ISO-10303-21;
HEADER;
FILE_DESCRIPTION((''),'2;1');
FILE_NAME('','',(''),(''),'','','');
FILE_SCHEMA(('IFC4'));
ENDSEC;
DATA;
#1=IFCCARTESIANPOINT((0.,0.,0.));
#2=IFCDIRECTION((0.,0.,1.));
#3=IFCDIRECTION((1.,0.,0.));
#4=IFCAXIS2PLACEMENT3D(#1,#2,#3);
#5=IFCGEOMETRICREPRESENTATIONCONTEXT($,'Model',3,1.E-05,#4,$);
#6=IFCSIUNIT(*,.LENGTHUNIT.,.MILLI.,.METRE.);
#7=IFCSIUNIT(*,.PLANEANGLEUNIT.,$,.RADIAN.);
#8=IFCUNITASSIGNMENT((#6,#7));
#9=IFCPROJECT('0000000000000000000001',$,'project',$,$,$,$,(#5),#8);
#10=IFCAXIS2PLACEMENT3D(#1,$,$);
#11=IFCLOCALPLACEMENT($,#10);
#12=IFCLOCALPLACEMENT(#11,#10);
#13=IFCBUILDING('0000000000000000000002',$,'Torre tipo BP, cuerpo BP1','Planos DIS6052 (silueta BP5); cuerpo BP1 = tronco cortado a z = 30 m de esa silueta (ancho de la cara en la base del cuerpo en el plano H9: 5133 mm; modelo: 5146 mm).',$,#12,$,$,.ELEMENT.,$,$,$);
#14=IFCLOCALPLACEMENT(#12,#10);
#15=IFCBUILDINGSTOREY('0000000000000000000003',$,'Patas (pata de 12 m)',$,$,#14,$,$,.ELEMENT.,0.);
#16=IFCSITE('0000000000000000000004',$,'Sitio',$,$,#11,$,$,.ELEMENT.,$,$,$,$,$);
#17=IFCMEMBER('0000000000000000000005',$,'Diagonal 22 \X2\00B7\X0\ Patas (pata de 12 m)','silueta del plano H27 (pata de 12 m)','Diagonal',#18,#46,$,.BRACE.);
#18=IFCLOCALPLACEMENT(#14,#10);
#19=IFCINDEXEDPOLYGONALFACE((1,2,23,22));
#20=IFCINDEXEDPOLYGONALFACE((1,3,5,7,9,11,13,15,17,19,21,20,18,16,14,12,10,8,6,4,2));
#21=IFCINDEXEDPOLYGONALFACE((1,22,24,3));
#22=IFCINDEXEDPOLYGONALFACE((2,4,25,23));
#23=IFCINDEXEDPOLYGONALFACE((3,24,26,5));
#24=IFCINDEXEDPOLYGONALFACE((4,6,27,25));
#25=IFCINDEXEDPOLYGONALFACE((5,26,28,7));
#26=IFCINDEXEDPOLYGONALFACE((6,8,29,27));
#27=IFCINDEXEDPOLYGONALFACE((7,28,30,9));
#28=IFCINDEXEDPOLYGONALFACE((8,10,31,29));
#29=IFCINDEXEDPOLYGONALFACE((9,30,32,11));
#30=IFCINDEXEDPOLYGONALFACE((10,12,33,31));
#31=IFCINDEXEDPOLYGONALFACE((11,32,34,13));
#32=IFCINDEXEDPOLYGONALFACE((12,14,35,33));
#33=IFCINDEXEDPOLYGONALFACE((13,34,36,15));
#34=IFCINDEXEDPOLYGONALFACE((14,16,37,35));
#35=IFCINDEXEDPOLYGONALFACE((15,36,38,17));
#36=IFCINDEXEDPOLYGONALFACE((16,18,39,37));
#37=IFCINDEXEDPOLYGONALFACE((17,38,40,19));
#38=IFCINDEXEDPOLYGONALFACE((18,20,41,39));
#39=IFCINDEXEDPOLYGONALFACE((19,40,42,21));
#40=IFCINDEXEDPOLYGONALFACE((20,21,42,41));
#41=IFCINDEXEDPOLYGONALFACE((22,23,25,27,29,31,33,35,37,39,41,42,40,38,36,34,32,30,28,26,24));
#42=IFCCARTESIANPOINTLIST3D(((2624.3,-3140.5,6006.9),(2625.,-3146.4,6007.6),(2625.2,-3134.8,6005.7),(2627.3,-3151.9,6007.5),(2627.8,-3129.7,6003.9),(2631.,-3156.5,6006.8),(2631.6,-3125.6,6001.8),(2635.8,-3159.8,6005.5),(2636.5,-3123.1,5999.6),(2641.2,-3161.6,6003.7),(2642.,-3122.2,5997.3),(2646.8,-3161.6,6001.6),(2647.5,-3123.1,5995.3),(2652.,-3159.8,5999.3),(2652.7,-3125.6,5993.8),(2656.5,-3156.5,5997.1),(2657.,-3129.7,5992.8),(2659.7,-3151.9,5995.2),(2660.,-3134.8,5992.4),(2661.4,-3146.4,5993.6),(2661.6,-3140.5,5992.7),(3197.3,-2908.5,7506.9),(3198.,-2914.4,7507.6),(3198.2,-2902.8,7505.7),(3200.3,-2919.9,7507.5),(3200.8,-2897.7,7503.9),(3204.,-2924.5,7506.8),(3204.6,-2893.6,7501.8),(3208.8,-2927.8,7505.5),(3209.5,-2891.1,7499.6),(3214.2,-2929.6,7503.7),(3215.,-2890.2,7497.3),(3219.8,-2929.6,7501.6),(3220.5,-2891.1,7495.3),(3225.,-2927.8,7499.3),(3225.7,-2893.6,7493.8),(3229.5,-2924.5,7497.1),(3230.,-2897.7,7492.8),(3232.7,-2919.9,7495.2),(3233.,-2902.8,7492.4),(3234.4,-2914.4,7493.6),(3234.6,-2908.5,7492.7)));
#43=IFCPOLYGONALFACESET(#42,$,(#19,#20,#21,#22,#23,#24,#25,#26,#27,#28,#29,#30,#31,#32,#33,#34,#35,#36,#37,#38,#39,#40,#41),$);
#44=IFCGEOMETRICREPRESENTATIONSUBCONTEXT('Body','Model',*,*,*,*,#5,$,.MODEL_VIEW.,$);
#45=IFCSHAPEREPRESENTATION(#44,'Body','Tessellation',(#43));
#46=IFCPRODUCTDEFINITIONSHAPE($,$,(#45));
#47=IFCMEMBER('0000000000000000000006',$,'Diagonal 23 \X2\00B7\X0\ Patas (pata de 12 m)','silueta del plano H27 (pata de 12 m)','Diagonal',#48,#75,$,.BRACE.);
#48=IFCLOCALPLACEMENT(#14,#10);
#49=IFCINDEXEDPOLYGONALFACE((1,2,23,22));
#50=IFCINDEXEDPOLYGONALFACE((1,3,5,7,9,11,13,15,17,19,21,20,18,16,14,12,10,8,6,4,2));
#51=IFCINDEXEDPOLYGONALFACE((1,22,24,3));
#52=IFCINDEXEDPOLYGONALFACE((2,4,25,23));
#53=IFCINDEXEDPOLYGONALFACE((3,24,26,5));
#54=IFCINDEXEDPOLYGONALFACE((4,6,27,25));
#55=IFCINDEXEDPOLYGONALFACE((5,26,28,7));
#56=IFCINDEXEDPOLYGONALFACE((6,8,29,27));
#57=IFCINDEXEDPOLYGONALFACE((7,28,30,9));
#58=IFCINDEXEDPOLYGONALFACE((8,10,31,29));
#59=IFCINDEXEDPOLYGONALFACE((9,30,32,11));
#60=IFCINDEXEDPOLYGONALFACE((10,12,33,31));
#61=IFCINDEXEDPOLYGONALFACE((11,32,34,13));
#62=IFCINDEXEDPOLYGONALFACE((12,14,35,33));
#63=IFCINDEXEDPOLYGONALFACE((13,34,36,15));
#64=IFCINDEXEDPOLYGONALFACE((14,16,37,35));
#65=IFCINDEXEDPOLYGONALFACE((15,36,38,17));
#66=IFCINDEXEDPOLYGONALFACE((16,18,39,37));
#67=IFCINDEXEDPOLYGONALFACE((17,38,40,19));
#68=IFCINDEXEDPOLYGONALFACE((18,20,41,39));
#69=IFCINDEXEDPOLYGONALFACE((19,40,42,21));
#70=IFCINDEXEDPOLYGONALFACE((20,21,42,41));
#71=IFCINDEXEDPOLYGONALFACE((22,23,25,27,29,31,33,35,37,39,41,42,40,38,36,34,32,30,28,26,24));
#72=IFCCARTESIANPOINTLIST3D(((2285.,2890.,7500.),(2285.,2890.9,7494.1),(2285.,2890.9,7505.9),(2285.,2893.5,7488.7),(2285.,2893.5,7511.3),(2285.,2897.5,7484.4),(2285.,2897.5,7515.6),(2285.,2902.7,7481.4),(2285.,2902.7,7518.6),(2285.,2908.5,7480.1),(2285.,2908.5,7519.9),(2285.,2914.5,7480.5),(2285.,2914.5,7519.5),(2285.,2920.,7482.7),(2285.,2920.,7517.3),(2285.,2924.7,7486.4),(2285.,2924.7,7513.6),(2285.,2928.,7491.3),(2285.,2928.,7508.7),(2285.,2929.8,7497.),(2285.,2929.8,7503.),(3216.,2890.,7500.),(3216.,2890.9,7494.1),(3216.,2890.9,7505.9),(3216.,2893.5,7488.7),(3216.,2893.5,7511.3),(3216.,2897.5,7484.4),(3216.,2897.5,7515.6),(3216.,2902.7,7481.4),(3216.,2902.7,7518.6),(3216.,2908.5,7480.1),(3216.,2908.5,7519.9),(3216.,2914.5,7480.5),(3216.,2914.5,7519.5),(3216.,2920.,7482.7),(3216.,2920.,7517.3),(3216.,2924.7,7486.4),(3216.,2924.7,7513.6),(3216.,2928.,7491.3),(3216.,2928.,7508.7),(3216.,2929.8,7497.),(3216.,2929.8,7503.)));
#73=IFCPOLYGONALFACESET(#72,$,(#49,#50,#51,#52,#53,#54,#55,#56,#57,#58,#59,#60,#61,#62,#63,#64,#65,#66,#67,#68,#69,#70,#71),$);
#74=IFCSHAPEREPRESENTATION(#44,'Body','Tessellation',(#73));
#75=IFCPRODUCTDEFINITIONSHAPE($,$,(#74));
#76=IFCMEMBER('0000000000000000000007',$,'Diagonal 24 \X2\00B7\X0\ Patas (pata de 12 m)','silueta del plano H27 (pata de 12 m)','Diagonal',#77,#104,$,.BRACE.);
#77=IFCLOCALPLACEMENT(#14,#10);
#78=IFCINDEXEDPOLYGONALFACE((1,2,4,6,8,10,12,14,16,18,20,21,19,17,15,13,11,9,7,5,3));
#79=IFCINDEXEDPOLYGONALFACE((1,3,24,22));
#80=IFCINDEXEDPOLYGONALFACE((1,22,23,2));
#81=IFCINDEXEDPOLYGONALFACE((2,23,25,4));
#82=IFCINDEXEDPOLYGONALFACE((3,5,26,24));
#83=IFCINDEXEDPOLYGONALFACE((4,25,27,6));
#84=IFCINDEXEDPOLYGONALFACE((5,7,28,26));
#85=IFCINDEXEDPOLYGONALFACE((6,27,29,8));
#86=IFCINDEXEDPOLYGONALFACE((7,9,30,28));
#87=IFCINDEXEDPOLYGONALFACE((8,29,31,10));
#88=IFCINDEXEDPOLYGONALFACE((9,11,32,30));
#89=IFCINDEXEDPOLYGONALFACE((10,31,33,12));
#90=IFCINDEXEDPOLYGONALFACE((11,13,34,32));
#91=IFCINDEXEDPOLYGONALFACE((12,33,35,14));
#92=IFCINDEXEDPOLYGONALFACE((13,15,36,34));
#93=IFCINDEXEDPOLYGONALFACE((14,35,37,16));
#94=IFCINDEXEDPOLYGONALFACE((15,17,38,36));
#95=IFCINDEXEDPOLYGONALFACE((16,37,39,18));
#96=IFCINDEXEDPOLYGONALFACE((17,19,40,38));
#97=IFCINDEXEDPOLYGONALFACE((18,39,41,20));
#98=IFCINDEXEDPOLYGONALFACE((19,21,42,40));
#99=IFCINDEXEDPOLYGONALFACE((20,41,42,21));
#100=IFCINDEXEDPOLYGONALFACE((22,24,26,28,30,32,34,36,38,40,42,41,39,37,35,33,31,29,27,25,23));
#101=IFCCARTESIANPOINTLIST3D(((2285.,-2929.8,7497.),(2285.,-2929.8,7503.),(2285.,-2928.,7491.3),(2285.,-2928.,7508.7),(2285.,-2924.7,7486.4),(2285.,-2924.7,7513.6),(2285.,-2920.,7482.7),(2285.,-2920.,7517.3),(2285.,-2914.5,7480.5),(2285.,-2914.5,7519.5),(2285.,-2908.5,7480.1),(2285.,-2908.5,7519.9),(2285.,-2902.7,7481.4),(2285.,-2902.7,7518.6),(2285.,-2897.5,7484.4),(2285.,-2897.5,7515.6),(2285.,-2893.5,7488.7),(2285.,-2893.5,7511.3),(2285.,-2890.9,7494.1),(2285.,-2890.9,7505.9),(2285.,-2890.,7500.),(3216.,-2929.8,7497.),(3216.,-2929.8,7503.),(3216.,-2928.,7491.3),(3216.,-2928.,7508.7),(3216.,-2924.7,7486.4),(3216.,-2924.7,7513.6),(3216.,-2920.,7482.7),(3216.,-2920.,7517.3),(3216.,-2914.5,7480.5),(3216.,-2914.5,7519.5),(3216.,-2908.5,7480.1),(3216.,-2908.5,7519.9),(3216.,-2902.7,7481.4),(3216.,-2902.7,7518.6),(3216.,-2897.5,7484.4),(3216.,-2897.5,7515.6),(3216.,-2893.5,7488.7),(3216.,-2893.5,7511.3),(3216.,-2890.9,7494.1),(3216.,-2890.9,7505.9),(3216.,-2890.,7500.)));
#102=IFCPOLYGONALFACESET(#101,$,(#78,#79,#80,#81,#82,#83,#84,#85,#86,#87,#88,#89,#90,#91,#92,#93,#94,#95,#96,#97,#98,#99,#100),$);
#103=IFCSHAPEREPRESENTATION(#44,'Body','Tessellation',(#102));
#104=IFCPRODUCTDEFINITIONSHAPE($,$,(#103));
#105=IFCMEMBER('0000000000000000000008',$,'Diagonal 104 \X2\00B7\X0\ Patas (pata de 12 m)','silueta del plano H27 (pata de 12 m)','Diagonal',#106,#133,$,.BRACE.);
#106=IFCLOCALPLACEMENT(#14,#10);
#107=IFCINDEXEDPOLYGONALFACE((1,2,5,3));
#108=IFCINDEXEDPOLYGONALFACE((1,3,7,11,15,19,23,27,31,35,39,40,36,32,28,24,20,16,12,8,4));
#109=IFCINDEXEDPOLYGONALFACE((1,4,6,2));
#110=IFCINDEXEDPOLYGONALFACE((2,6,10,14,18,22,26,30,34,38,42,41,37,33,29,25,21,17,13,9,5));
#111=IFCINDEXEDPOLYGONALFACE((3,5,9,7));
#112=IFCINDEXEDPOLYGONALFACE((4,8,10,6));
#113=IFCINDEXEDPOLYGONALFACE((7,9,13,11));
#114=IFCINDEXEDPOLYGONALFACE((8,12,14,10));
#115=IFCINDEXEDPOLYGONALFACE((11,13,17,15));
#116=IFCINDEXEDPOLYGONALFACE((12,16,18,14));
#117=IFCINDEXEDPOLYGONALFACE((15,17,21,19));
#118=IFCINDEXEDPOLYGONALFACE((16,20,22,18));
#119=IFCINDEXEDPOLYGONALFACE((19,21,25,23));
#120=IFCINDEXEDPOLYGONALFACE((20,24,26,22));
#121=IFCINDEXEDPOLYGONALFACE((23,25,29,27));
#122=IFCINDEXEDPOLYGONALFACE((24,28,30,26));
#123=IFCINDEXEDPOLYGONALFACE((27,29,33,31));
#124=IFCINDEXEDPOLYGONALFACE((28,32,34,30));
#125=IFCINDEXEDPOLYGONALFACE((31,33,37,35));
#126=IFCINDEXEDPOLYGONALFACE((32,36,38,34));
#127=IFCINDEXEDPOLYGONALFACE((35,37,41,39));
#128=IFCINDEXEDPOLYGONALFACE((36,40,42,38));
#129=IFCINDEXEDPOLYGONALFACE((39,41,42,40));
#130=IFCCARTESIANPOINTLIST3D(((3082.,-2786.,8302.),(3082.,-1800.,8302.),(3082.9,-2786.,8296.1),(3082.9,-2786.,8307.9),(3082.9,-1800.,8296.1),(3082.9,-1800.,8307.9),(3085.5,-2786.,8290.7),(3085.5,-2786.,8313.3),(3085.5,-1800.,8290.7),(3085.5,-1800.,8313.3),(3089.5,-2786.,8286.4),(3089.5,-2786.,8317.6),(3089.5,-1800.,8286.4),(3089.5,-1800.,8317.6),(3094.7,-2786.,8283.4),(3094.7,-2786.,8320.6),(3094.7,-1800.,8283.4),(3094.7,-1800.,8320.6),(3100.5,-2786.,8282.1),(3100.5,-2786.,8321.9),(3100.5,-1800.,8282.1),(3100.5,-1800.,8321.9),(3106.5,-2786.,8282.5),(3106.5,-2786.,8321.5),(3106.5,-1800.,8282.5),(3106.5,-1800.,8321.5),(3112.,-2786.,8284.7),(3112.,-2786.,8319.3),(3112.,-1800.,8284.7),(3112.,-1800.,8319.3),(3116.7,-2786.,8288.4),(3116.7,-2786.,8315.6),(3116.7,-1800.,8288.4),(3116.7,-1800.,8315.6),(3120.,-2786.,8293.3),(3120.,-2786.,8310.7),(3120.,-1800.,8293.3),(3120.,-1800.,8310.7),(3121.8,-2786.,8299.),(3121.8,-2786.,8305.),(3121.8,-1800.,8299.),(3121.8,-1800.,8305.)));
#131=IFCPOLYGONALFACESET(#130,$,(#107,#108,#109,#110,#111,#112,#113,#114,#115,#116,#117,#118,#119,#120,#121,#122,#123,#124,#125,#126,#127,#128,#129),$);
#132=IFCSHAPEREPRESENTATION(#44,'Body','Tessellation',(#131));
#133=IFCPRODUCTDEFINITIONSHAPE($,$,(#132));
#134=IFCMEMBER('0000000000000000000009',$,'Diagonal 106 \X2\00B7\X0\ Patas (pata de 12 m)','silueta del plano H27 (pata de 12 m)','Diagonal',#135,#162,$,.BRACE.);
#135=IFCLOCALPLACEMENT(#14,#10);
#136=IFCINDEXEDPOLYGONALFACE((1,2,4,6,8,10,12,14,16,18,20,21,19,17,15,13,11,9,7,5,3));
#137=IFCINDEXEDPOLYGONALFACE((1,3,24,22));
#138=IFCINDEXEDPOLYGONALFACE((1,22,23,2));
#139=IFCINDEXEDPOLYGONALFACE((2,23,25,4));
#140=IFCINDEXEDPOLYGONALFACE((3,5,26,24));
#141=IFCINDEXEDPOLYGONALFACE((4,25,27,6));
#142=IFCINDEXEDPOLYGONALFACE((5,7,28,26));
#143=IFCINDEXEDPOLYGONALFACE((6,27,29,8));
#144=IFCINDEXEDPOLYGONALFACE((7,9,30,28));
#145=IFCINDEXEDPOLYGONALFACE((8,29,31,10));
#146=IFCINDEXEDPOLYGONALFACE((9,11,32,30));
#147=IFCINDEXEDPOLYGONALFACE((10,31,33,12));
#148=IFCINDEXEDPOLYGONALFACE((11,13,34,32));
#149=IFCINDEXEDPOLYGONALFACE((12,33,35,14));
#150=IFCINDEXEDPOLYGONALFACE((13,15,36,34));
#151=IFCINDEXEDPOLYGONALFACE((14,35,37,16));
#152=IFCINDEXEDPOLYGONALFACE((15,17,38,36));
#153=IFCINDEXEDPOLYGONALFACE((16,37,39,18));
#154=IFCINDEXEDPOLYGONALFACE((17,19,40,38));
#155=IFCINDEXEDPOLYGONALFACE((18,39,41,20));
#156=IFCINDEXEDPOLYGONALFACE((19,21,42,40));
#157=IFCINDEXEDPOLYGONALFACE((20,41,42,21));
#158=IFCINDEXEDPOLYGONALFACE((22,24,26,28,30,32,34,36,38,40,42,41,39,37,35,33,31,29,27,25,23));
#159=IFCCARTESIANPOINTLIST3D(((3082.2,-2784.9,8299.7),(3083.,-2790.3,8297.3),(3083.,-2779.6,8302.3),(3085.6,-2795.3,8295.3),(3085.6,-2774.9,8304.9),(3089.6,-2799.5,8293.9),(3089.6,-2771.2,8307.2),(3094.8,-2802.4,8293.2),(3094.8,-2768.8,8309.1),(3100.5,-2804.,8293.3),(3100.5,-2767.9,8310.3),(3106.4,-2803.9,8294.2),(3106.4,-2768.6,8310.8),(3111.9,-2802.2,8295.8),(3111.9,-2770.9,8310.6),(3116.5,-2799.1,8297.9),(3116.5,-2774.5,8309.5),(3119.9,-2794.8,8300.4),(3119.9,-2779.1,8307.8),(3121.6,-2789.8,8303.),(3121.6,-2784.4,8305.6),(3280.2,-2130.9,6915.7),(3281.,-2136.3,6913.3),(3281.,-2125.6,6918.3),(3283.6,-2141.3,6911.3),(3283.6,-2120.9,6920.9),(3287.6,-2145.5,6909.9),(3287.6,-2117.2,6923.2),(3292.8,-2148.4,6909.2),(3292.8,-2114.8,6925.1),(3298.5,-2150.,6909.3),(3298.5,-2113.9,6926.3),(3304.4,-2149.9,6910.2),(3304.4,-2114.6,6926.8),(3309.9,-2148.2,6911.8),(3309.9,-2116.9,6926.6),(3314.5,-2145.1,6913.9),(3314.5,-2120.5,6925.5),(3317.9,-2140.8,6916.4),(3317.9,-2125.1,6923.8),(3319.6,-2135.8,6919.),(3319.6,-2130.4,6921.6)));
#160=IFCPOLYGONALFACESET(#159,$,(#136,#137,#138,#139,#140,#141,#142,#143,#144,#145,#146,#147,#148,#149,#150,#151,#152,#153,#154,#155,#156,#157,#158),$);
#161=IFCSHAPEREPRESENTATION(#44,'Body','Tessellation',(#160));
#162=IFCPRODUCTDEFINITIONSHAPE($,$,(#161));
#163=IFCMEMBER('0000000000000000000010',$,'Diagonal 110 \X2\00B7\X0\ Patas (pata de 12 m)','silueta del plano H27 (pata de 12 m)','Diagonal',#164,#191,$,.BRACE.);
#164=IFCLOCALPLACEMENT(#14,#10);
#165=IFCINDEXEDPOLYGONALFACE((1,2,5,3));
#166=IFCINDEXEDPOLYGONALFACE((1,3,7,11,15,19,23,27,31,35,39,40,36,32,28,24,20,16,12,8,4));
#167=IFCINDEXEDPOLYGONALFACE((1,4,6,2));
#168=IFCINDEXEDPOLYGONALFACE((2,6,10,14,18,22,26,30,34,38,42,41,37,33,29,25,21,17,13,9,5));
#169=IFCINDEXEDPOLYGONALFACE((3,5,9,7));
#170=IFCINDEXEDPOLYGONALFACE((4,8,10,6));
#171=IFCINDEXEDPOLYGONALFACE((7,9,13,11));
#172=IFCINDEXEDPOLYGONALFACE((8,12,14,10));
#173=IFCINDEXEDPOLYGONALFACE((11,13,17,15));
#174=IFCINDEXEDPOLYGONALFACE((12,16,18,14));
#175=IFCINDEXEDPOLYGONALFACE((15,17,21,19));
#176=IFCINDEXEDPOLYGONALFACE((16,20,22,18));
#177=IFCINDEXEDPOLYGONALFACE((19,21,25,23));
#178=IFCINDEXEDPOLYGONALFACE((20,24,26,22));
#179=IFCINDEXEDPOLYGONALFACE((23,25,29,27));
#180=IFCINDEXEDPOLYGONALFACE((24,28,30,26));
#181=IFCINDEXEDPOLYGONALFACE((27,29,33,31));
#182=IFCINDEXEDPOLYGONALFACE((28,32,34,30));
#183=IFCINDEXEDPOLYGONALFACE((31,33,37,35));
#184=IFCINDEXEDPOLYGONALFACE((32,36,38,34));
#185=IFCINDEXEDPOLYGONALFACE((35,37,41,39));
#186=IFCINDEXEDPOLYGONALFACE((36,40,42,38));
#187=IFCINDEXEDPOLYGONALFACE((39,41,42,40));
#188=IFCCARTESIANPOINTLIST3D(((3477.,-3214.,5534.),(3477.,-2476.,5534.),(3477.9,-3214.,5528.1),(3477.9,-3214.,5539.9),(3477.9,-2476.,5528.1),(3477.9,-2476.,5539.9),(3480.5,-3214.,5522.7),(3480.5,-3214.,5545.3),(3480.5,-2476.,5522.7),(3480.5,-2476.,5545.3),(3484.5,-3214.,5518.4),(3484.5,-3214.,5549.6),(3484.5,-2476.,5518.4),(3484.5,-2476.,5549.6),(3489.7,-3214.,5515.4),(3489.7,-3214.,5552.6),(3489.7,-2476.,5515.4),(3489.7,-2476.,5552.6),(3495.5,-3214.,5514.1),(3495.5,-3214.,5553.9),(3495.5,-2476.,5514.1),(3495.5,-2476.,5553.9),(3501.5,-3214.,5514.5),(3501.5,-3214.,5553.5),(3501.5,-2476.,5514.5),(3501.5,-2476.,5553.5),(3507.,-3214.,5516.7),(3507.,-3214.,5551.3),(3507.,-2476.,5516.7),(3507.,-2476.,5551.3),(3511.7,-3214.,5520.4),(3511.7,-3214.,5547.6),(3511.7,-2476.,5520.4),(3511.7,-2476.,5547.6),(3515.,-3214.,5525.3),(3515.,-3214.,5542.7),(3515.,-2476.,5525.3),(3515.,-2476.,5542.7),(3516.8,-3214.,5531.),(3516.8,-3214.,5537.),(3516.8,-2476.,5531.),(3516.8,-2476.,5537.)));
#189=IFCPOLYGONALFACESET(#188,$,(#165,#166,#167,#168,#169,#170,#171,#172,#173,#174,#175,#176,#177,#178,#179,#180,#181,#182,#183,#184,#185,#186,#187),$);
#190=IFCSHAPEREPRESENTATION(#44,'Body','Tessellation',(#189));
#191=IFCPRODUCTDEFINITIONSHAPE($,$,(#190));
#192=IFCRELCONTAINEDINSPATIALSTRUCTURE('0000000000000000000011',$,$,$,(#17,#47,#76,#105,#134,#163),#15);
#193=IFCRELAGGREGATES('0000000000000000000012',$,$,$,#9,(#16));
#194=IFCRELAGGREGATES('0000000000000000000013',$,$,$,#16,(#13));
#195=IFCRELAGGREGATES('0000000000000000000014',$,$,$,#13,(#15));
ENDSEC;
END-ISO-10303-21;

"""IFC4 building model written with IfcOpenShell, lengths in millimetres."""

from ifc_helpers import new_model, si_unit, frame, origin, origin_with_axes, place, context, subcontext, project, spatial, circle, extrude, element, save


model = new_model("IFC4")

# Units and contexts
model_context = context("Model", 3, precision=1e-05, world=origin_with_axes())
body_context = subcontext(model_context, "Body", "Model", "MODEL_VIEW")
ifc_project = project(units=[si_unit("LENGTHUNIT", "METRE", prefix="MILLI"), si_unit("PLANEANGLEUNIT", "RADIAN")], contexts=[model_context])

# Site, building, storey
site_placement = place(None, origin())
site = spatial("IfcSite", under=ifc_project, at=site_placement, Name="Sitio", CompositionType="ELEMENT")
building_placement = place(site_placement, origin())
building = spatial("IfcBuilding", under=site, at=building_placement, Name="Torre tipo BP, cuerpo BP1", Description="Planos DIS6052 (silueta BP5); cuerpo BP1 = tronco cortado a z = 30 m de esa silueta (ancho de la cara en la base del cuerpo en el plano H9: 5133 mm; modelo: 5146 mm).", CompositionType="ELEMENT")
storey_placement = place(building_placement, origin())
storey = spatial("IfcBuildingStorey", under=building, at=storey_placement, Name="Patas (pata de 12 m)", CompositionType="ELEMENT", Elevation=0.0)

# Members
for number, where, z_axis, x_axis, name in (
    (1, (2643.0, -3142.0, 6000.0), (0.353182, 0.142999, 0.924561), (-0.051029, 0.989723, -0.133584), "Diagonal 22 · Patas (pata de 12 m)"),
):
    element("IfcMember", number, at=place(storey_placement, frame(where, z_axis=z_axis, x_axis=x_axis)), inside=storey, Name=name, Description="silueta del plano H27 (pata de 12 m)", ObjectType="Diagonal", PredefinedType="BRACE", context=body_context, shape_type="SweptSolid", body=[
        extrude(circle(Radius=20.0), None, (0.0, 0.0, 1.0), 1622.4),
    ])
for number, where, z_axis, x_axis, name in (
    (2, (3216.0, 2910.0, 7500.0), (-1.0, 0.0, 0.0), (0.0, -1.0, 0.0), "Diagonal 23 · Patas (pata de 12 m)"),
    (3, (3216.0, -2910.0, 7500.0), (-1.0, 0.0, 0.0), (0.0, 1.0, 0.0), "Diagonal 24 · Patas (pata de 12 m)"),
):
    element("IfcMember", number, at=place(storey_placement, frame(where, z_axis=z_axis, x_axis=x_axis)), inside=storey, Name=name, Description="silueta del plano H27 (pata de 12 m)", ObjectType="Diagonal", PredefinedType="BRACE", context=body_context, shape_type="SweptSolid", body=[
        extrude(circle(Radius=20.0), None, (0.0, 0.0, 1.0), 931.0),
    ])
member_1_placement = place(storey_placement, frame((3102.0, -2786.0, 8302.0), z_axis=(0.0, 1.0, 0.0), x_axis=(-1.0, 0.0, 0.0)))
element("IfcMember", 4, at=member_1_placement, inside=storey, Name="Diagonal 104 · Patas (pata de 12 m)", Description="silueta del plano H27 (pata de 12 m)", ObjectType="Diagonal", PredefinedType="BRACE", context=body_context, shape_type="SweptSolid", body=[
    extrude(circle(Radius=20.0), None, (0.0, 0.0, 1.0), 986.0),
])
member_2_placement = place(storey_placement, frame((3300.0, -2132.0, 6918.0), z_axis=(-0.12828, -0.423714, 0.896666), x_axis=(-0.991738, 0.054807, -0.115983)))
element("IfcMember", 5, at=member_2_placement, inside=storey, Name="Diagonal 106 · Patas (pata de 12 m)", Description="silueta del plano H27 (pata de 12 m)", ObjectType="Diagonal", PredefinedType="BRACE", context=body_context, shape_type="SweptSolid", body=[
    extrude(circle(Radius=20.0), None, (0.0, 0.0, 1.0), 1543.5),
])
member_3_placement = place(storey_placement, frame((3497.0, -3214.0, 5534.0), z_axis=(0.0, 1.0, 0.0), x_axis=(-1.0, 0.0, 0.0)))
element("IfcMember", 6, at=member_3_placement, inside=storey, Name="Diagonal 110 · Patas (pata de 12 m)", Description="silueta del plano H27 (pata de 12 m)", ObjectType="Diagonal", PredefinedType="BRACE", context=body_context, shape_type="SweptSolid", body=[
    extrude(circle(Radius=20.0), None, (0.0, 0.0, 1.0), 738.0),
])

save(model, "model.ifc")
